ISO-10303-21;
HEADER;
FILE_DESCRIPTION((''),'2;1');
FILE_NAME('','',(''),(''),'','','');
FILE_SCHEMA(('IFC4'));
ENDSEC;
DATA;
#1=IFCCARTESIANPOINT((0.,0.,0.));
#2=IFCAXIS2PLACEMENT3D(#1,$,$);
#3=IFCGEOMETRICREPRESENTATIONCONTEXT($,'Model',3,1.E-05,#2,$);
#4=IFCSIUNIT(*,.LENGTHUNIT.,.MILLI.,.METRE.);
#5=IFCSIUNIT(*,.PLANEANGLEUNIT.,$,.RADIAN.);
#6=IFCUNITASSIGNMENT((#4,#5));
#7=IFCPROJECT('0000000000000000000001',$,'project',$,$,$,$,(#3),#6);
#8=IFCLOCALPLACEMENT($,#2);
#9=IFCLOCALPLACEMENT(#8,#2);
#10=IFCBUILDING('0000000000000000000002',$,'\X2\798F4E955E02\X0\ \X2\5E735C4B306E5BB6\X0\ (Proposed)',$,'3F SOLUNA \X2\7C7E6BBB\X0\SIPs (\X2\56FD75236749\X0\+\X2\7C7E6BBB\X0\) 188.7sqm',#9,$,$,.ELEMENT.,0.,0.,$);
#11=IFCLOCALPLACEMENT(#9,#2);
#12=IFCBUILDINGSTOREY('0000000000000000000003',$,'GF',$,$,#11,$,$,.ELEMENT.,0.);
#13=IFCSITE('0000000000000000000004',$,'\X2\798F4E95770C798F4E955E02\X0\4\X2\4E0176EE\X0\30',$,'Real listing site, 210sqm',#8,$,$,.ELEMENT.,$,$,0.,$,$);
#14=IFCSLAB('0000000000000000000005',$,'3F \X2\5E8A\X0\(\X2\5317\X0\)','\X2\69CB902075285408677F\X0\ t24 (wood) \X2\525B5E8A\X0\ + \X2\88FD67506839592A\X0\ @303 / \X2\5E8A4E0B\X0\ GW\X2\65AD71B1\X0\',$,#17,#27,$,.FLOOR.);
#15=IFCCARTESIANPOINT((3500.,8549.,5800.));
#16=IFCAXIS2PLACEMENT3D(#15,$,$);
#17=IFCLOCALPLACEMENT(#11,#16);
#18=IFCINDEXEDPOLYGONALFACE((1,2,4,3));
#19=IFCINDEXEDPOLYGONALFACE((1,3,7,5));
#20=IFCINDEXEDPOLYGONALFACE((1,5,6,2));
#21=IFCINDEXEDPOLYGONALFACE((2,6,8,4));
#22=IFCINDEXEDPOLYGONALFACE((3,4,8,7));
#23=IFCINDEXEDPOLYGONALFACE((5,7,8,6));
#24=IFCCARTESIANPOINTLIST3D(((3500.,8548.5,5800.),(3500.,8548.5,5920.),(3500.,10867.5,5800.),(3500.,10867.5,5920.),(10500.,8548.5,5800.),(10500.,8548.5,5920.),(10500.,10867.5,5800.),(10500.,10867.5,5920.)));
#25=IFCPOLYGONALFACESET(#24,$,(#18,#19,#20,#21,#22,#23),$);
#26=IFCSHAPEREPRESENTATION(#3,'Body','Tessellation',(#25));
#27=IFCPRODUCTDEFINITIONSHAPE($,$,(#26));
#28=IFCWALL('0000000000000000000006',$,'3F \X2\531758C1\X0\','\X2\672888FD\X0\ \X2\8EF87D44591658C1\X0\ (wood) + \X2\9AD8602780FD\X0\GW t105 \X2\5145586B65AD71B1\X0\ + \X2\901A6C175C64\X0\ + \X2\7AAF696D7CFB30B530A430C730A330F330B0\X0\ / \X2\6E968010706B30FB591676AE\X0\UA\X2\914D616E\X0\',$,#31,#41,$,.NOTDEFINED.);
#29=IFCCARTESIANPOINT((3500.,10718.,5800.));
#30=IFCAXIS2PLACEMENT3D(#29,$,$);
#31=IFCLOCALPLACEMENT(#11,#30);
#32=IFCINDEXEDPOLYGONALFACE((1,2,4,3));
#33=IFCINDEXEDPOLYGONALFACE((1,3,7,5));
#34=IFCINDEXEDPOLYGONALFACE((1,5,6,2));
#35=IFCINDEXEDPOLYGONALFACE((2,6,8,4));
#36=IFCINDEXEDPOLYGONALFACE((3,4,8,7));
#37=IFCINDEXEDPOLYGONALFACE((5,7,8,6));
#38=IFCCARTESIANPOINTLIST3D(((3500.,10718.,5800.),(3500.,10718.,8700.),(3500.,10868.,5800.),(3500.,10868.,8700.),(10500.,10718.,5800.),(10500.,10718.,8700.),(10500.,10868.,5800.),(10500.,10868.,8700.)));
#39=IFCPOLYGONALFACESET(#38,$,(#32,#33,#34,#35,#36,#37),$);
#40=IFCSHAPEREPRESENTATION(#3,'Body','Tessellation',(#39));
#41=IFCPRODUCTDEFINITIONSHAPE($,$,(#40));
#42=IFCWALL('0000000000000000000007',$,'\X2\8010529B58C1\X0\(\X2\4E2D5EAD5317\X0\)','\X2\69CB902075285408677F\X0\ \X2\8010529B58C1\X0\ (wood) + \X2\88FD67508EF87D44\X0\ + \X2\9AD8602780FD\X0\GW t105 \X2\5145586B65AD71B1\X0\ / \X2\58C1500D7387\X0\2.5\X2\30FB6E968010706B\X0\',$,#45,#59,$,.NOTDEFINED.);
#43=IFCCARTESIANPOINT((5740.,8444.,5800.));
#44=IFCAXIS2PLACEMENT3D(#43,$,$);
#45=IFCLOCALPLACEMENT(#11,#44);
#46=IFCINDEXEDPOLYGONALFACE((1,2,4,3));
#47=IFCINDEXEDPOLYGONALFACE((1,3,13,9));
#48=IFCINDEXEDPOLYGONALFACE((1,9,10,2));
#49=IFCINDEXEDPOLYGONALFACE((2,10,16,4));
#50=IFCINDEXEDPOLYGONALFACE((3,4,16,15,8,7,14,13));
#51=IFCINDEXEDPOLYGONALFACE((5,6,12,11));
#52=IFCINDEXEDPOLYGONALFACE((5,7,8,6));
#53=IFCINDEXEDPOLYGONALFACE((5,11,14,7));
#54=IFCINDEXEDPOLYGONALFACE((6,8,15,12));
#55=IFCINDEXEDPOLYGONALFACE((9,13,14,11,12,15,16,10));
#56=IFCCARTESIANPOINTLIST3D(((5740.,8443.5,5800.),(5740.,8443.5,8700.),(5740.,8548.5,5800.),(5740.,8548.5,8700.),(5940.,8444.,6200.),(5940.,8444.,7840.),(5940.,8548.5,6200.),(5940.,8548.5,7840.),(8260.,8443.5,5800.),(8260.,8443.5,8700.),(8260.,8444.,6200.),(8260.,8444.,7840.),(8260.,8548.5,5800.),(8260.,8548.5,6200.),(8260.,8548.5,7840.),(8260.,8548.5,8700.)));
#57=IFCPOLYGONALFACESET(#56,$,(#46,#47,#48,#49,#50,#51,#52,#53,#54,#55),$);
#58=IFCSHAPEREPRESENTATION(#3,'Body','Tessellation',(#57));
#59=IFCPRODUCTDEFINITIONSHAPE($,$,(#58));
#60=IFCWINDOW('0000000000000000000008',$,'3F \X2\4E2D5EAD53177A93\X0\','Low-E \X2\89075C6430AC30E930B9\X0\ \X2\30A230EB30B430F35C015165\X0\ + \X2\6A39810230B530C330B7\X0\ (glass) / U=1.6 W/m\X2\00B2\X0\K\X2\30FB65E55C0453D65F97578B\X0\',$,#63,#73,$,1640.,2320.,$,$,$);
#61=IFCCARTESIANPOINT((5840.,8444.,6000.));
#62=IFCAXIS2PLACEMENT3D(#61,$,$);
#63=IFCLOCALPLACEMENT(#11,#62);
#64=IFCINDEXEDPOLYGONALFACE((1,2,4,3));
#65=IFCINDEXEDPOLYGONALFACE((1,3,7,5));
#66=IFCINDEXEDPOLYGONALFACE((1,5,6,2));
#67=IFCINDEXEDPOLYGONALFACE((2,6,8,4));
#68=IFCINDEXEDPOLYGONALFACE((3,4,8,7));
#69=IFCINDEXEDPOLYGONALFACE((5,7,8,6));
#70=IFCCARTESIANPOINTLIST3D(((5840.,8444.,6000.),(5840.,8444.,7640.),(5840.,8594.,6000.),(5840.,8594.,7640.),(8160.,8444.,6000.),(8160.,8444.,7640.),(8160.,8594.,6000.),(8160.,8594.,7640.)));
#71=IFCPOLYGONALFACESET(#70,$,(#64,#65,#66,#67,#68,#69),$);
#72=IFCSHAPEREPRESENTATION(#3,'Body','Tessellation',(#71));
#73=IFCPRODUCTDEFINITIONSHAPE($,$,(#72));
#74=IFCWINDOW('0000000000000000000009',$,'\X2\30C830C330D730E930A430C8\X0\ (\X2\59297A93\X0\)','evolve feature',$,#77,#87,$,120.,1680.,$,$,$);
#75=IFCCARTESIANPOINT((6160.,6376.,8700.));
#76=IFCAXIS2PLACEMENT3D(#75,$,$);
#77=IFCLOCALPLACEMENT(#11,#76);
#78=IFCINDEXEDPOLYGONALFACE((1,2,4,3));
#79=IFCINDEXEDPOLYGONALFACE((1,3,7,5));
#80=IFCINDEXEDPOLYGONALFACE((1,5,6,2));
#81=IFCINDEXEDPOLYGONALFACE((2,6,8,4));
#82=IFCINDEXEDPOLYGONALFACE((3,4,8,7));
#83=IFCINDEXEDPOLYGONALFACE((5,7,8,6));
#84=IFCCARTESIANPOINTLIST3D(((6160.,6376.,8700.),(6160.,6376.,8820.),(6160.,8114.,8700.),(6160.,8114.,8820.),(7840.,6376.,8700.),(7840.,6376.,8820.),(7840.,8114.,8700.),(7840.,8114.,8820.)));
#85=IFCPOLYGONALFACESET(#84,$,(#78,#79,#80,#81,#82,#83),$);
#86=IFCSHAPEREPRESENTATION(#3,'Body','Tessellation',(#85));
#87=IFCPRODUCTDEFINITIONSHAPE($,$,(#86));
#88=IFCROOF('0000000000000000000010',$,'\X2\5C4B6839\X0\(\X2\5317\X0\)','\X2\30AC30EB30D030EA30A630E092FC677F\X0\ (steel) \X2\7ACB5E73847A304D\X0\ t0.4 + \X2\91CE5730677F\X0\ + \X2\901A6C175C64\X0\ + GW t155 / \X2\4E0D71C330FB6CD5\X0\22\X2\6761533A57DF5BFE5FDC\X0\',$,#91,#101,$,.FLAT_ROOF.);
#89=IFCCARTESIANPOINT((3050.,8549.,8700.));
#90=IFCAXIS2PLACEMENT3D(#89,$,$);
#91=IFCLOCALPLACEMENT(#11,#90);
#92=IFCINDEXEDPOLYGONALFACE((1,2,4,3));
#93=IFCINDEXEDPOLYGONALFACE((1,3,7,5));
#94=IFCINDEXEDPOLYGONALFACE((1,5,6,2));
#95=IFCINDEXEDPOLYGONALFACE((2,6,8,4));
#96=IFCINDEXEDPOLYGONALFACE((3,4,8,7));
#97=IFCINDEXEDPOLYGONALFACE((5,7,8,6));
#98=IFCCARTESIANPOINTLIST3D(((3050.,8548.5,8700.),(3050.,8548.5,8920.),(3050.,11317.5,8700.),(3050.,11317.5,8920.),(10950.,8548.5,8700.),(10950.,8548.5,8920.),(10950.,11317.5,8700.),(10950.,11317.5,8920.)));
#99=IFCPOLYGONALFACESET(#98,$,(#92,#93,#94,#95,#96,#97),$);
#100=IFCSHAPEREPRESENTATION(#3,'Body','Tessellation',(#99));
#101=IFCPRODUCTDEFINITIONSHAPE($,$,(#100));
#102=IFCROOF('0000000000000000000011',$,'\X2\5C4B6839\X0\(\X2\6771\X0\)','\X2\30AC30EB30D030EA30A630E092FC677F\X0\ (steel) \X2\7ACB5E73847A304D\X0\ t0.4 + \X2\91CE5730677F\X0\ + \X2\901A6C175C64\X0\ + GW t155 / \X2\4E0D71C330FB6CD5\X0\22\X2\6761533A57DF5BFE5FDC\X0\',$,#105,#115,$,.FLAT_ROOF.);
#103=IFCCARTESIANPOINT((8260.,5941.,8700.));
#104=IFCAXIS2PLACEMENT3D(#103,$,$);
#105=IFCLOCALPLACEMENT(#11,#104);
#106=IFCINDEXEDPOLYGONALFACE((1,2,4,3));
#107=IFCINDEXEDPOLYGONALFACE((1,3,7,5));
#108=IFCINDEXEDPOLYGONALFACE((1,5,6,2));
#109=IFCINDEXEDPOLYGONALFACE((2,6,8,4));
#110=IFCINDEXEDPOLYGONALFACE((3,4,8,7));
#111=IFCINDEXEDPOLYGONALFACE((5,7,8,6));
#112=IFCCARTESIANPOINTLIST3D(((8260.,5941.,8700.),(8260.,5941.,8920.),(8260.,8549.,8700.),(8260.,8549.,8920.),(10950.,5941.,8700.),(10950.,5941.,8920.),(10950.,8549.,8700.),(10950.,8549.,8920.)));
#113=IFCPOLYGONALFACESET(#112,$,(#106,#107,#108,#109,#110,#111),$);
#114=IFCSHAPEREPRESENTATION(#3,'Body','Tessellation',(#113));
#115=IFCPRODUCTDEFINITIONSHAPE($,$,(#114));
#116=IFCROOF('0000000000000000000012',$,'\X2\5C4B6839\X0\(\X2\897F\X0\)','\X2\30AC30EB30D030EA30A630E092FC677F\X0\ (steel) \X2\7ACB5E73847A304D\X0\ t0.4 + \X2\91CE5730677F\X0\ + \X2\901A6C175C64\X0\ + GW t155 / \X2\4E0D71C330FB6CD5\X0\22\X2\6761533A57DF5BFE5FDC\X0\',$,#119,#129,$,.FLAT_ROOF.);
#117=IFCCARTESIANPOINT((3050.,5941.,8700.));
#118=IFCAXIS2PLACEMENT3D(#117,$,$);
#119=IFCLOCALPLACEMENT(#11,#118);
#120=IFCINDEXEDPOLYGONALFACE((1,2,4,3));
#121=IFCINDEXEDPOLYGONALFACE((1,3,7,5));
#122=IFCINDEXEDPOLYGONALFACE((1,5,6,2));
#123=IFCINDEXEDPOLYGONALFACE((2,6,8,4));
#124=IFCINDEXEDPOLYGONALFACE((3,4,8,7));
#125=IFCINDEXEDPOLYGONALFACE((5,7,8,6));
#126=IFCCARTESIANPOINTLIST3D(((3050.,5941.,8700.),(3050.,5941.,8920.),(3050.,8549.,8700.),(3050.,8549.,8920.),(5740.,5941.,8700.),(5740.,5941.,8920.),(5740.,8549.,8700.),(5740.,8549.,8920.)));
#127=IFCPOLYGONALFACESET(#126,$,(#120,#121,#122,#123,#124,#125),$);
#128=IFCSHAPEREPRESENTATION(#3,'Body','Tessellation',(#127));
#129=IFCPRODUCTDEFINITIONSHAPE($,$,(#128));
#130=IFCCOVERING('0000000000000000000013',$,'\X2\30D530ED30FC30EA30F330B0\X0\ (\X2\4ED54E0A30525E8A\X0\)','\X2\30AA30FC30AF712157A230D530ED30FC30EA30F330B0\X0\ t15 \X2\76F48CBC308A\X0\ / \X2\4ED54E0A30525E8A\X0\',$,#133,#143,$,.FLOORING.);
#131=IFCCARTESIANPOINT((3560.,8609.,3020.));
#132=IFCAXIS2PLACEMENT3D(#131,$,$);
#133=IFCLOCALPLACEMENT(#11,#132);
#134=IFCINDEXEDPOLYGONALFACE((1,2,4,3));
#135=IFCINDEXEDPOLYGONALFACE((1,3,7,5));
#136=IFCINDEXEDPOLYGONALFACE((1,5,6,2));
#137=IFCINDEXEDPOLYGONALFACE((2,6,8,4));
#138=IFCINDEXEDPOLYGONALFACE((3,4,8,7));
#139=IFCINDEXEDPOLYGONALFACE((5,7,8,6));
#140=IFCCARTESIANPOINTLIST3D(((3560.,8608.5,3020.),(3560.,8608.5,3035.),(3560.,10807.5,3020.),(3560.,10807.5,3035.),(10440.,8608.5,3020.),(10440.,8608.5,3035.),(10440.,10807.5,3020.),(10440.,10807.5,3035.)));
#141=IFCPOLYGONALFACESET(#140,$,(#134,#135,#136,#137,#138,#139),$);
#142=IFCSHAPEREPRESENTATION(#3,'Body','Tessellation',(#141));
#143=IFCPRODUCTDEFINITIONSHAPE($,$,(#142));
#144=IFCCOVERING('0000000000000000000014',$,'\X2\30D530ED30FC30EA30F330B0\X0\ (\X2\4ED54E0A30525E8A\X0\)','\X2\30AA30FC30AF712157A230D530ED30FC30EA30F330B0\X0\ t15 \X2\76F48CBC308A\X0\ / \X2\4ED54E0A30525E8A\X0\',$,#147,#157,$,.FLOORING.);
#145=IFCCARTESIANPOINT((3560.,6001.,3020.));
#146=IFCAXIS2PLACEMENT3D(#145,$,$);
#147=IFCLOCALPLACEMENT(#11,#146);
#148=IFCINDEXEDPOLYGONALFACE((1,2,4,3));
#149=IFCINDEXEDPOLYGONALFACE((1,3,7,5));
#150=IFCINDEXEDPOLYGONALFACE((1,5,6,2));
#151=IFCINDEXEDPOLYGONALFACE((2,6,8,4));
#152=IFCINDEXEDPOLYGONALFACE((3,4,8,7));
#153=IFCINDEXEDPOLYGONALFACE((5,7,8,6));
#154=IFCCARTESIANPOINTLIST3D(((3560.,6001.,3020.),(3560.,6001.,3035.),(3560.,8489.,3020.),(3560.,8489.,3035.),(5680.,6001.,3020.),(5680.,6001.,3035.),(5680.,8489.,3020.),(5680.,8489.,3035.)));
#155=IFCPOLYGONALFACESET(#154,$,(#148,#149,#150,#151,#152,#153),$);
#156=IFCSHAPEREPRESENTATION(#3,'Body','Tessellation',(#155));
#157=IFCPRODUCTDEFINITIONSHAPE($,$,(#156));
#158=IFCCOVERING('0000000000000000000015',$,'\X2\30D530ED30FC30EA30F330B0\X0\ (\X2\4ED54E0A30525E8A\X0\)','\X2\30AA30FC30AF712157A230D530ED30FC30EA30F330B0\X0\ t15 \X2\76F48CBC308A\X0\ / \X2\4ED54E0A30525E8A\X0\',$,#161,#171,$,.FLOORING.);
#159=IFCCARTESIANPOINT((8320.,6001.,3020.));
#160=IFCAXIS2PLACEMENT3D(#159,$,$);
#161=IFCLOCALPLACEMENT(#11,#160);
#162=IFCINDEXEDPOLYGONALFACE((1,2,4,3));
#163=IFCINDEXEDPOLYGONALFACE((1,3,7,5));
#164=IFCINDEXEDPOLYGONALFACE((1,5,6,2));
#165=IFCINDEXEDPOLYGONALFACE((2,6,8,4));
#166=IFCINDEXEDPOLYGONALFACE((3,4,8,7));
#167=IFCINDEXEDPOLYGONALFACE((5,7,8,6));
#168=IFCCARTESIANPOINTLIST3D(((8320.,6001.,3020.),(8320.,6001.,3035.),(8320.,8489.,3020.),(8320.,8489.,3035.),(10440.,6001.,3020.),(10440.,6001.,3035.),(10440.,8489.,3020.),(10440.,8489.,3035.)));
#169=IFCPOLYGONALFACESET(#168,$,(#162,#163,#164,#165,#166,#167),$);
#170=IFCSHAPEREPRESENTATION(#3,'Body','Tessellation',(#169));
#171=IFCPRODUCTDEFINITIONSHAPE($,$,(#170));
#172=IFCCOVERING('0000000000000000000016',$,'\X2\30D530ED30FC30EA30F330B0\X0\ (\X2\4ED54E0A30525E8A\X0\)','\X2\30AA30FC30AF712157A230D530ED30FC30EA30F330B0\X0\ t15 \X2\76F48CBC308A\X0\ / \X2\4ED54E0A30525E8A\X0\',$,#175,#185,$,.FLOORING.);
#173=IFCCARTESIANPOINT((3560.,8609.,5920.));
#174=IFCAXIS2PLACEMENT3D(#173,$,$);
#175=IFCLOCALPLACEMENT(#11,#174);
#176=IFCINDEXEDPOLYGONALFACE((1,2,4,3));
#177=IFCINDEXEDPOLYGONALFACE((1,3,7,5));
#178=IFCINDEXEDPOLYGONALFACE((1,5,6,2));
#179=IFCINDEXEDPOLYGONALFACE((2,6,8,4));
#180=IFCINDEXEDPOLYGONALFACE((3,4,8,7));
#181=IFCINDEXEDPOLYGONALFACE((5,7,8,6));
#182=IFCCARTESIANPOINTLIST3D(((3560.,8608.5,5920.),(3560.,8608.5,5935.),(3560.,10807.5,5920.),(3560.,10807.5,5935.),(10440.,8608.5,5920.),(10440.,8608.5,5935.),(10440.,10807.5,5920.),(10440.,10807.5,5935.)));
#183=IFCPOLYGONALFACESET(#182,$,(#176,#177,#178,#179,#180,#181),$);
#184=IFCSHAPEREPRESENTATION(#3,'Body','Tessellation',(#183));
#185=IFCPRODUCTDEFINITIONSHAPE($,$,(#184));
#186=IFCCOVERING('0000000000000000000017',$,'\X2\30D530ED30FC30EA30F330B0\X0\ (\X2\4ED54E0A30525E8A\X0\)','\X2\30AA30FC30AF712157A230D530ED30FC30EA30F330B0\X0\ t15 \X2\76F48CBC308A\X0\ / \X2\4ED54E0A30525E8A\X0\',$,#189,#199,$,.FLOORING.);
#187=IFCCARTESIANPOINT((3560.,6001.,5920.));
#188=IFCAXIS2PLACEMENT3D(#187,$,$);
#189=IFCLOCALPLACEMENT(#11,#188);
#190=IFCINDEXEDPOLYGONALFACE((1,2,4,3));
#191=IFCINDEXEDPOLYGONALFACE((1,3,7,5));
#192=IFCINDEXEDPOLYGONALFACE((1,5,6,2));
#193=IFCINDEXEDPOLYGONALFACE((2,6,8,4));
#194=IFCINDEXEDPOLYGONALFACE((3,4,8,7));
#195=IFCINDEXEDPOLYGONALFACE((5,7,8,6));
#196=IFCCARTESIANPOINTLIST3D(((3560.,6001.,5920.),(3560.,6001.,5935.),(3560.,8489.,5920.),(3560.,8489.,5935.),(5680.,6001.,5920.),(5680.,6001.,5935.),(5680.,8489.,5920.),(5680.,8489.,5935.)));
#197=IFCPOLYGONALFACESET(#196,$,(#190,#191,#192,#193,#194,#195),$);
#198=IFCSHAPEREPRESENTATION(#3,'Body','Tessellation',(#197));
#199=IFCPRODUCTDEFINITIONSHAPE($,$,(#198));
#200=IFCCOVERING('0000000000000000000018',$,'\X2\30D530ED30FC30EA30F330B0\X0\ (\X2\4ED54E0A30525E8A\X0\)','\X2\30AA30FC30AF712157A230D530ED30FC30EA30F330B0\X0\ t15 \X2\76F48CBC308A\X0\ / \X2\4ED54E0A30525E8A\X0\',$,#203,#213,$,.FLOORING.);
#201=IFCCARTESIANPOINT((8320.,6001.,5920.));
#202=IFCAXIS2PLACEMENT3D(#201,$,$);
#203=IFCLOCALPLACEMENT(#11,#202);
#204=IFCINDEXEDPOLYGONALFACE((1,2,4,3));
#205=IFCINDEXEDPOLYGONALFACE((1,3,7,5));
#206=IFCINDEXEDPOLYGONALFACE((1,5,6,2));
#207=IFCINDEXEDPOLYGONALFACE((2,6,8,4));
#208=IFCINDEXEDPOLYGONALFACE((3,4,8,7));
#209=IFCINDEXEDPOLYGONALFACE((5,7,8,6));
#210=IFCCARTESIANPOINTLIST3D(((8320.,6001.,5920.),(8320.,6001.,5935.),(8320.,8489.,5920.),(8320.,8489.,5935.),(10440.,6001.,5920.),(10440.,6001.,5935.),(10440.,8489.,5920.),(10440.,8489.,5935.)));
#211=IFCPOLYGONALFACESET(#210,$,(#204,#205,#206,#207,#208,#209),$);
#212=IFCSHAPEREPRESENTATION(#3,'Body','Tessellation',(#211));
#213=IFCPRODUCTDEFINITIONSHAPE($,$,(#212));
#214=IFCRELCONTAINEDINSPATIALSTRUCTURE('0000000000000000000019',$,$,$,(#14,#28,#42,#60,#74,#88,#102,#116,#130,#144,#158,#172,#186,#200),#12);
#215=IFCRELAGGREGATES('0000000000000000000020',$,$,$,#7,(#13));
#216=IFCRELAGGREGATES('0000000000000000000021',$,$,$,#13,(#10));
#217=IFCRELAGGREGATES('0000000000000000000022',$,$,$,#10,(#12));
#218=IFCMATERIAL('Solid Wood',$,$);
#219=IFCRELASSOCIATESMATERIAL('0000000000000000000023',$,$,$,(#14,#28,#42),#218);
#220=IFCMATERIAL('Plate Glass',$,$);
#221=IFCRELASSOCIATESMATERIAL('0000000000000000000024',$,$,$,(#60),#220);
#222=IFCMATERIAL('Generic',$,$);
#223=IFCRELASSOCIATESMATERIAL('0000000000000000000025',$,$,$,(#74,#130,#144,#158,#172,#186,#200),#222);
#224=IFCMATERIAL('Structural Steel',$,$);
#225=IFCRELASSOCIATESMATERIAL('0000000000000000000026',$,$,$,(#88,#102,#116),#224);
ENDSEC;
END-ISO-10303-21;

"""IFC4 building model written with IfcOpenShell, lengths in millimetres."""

from ifc_helpers import new_model, si_unit, frame, frame_2d, origin, place, context, project, spatial, rectangle, extrude, material, element, fill, save


model = new_model("IFC4")

# Units and contexts
model_context = context("Model", 3, precision=1e-05, world=origin())
ifc_project = project(units=[si_unit("LENGTHUNIT", "METRE", prefix="MILLI"), si_unit("PLANEANGLEUNIT", "RADIAN")], contexts=[model_context])

# Site, building, storey
site_placement = place(None, origin())
site = spatial("IfcSite", under=ifc_project, at=site_placement, Name="福井県福井市4丁目30", ObjectType="Real listing site, 210sqm", CompositionType="ELEMENT", RefElevation=0.0)
building_placement = place(site_placement, origin())
building = spatial("IfcBuilding", under=site, at=building_placement, Name="福井市 平屋の家 (Proposed)", ObjectType="3F SOLUNA 籾殻SIPs (国産杉+籾殻) 188.7sqm", CompositionType="ELEMENT", ElevationOfRefHeight=0.0, ElevationOfTerrain=0.0)
storey_placement = place(building_placement, origin())
storey = spatial("IfcBuildingStorey", under=building, at=storey_placement, Name="GF", CompositionType="ELEMENT", Elevation=0.0)

# Slab
ifc_material_1 = material(Name="Solid Wood")
slab_placement = place(storey_placement, frame((3500.0, 8549.0, 5800.0)))
element("IfcSlab", 1, at=slab_placement, inside=storey, material=ifc_material_1, Name="3F 床(北)", Description="構造用合板 t24 (wood) 剛床 + 製材根太 @303 / 床下 GW断熱", PredefinedType="FLOOR", context=model_context, shape_type="SweptSolid", body=[
    extrude(rectangle(XDim=7000.0, YDim=2319.0, at=frame_2d((3500.0, 1159.0))), frame((3500.0, 8549.0, 5800.0)), (0.0, 0.0, 1.0), 120.0),
])

# Wall
wall_1_placement = place(storey_placement, frame((3500.0, 10718.0, 5800.0)))
element("IfcWall", 2, at=wall_1_placement, inside=storey, material=ifc_material_1, Name="3F 北壁", Description="木製 軸組外壁 (wood) + 高性能GW t105 充填断熱 + 通気層 + 窯業系サイディング / 準耐火・外皮UA配慮", PredefinedType="NOTDEFINED", context=model_context, shape_type="SweptSolid", body=[
    extrude(rectangle(XDim=7000.0, YDim=150.0, at=frame_2d((3500.0, 75.0))), frame((3500.0, 10718.0, 5800.0)), (0.0, 0.0, 1.0), 2900.0),
])

# Wall, opening, window
wall_2_placement = place(storey_placement, frame((5740.0, 8444.0, 5800.0)))
wall_2 = element("IfcWall", 3, at=wall_2_placement, inside=storey, material=ifc_material_1, Name="耐力壁(中庭北)", Description="構造用合板 耐力壁 (wood) + 製材軸組 + 高性能GW t105 充填断熱 / 壁倍率2.5・準耐火", PredefinedType="NOTDEFINED", context=model_context, shape_type="SweptSolid", body=[
    extrude(rectangle(XDim=2520.0, YDim=105.0, at=frame_2d((1260.0, 52.0))), frame((5740.0, 8444.0, 5800.0)), (0.0, 0.0, 1.0), 2900.0),
])
opening_placement = place(storey_placement, frame((5840.0, 8444.0, 6000.0)))
opening = element("IfcOpeningElement", 4, at=opening_placement, cuts=wall_2, PredefinedType="NOTDEFINED", context=model_context, shape_type="SweptSolid", body=[
    extrude(rectangle(XDim=2320.0, YDim=150.0, at=frame_2d((1160.0, 75.0))), frame((5840.0, 8444.0, 6000.0)), (0.0, 0.0, 1.0), 1640.0),
])
ifc_material_2 = material(Name="Plate Glass")
window_1_placement = place(storey_placement, frame((5840.0, 8444.0, 6000.0)))
window_1 = element("IfcWindow", 5, at=window_1_placement, inside=storey, material=ifc_material_2, Name="3F 中庭北窓", Description="Low-E 複層ガラス アルゴン封入 + 樹脂サッシ (glass) / U=1.6 W/m²K・日射取得型", OverallHeight=1640.0, OverallWidth=2320.0, context=model_context, shape_type="SweptSolid", body=[
    extrude(rectangle(XDim=2320.0, YDim=150.0, at=frame_2d((1160.0, 75.0))), frame((5840.0, 8444.0, 6000.0)), (0.0, 0.0, 1.0), 1640.0),
])
fill(opening, window_1)

# Window
ifc_material_3 = material(Name="Generic")
window_2_placement = place(storey_placement, frame((6160.0, 6376.0, 8700.0)))
element("IfcWindow", 6, at=window_2_placement, inside=storey, material=ifc_material_3, Name="トップライト (天窓)", Description="evolve feature", OverallHeight=120.0, OverallWidth=1680.0, context=model_context, shape_type="SweptSolid", body=[
    extrude(rectangle(XDim=1680.0, YDim=1738.0, at=frame_2d((840.0, 869.0))), frame((6160.0, 6376.0, 8700.0)), (0.0, 0.0, 1.0), 120.0),
])

# Roofs
ifc_material_4 = material(Name="Structural Steel")
roof_1_placement = place(storey_placement, frame((3050.0, 8549.0, 8700.0)))
element("IfcRoof", 7, at=roof_1_placement, inside=storey, material=ifc_material_4, Name="屋根(北)", Description="ガルバリウム鋼板 (steel) 立平葺き t0.4 + 野地板 + 通気層 + GW t155 / 不燃・法22条区域対応", PredefinedType="FLAT_ROOF", context=model_context, shape_type="SweptSolid", body=[
    extrude(rectangle(XDim=7900.0, YDim=2769.0, at=frame_2d((3950.0, 1384.0))), frame((3050.0, 8549.0, 8700.0)), (0.0, 0.0, 1.0), 220.0),
])
roof_2_placement = place(storey_placement, frame((8260.0, 5941.0, 8700.0)))
element("IfcRoof", 8, at=roof_2_placement, inside=storey, material=ifc_material_4, Name="屋根(東)", Description="ガルバリウム鋼板 (steel) 立平葺き t0.4 + 野地板 + 通気層 + GW t155 / 不燃・法22条区域対応", PredefinedType="FLAT_ROOF", context=model_context, shape_type="SweptSolid", body=[
    extrude(rectangle(XDim=2690.0, YDim=2608.0, at=frame_2d((1345.0, 1304.0))), frame((8260.0, 5941.0, 8700.0)), (0.0, 0.0, 1.0), 220.0),
])
roof_3_placement = place(storey_placement, frame((3050.0, 5941.0, 8700.0)))
element("IfcRoof", 9, at=roof_3_placement, inside=storey, material=ifc_material_4, Name="屋根(西)", Description="ガルバリウム鋼板 (steel) 立平葺き t0.4 + 野地板 + 通気層 + GW t155 / 不燃・法22条区域対応", PredefinedType="FLAT_ROOF", context=model_context, shape_type="SweptSolid", body=[
    extrude(rectangle(XDim=2690.0, YDim=2608.0, at=frame_2d((1345.0, 1304.0))), frame((3050.0, 5941.0, 8700.0)), (0.0, 0.0, 1.0), 220.0),
])

# Coverings
covering_1_placement = place(storey_placement, frame((3560.0, 8609.0, 3020.0)))
element("IfcCovering", 10, at=covering_1_placement, inside=storey, material=ifc_material_3, Name="フローリング (仕上げ床)", Description="オーク無垢フローリング t15 直貼り / 仕上げ床", PredefinedType="FLOORING", context=model_context, shape_type="SweptSolid", body=[
    extrude(rectangle(XDim=6880.0, YDim=2199.0, at=frame_2d((3440.0, 1099.0))), frame((3560.0, 8609.0, 3020.0)), (0.0, 0.0, 1.0), 15.0),
])
covering_2_placement = place(storey_placement, frame((3560.0, 6001.0, 3020.0)))
element("IfcCovering", 11, at=covering_2_placement, inside=storey, material=ifc_material_3, Name="フローリング (仕上げ床)", Description="オーク無垢フローリング t15 直貼り / 仕上げ床", PredefinedType="FLOORING", context=model_context, shape_type="SweptSolid", body=[
    extrude(rectangle(XDim=2120.0, YDim=2488.0, at=frame_2d((1060.0, 1244.0))), frame((3560.0, 6001.0, 3020.0)), (0.0, 0.0, 1.0), 15.0),
])
covering_3_placement = place(storey_placement, frame((8320.0, 6001.0, 3020.0)))
element("IfcCovering", 12, at=covering_3_placement, inside=storey, material=ifc_material_3, Name="フローリング (仕上げ床)", Description="オーク無垢フローリング t15 直貼り / 仕上げ床", PredefinedType="FLOORING", context=model_context, shape_type="SweptSolid", body=[
    extrude(rectangle(XDim=2120.0, YDim=2488.0, at=frame_2d((1060.0, 1244.0))), frame((8320.0, 6001.0, 3020.0)), (0.0, 0.0, 1.0), 15.0),
])
covering_4_placement = place(storey_placement, frame((3560.0, 8609.0, 5920.0)))
element("IfcCovering", 13, at=covering_4_placement, inside=storey, material=ifc_material_3, Name="フローリング (仕上げ床)", Description="オーク無垢フローリング t15 直貼り / 仕上げ床", PredefinedType="FLOORING", context=model_context, shape_type="SweptSolid", body=[
    extrude(rectangle(XDim=6880.0, YDim=2199.0, at=frame_2d((3440.0, 1099.0))), frame((3560.0, 8609.0, 5920.0)), (0.0, 0.0, 1.0), 15.0),
])
covering_5_placement = place(storey_placement, frame((3560.0, 6001.0, 5920.0)))
element("IfcCovering", 14, at=covering_5_placement, inside=storey, material=ifc_material_3, Name="フローリング (仕上げ床)", Description="オーク無垢フローリング t15 直貼り / 仕上げ床", PredefinedType="FLOORING", context=model_context, shape_type="SweptSolid", body=[
    extrude(rectangle(XDim=2120.0, YDim=2488.0, at=frame_2d((1060.0, 1244.0))), frame((3560.0, 6001.0, 5920.0)), (0.0, 0.0, 1.0), 15.0),
])
covering_6_placement = place(storey_placement, frame((8320.0, 6001.0, 5920.0)))
element("IfcCovering", 15, at=covering_6_placement, inside=storey, material=ifc_material_3, Name="フローリング (仕上げ床)", Description="オーク無垢フローリング t15 直貼り / 仕上げ床", PredefinedType="FLOORING", context=model_context, shape_type="SweptSolid", body=[
    extrude(rectangle(XDim=2120.0, YDim=2488.0, at=frame_2d((1060.0, 1244.0))), frame((8320.0, 6001.0, 5920.0)), (0.0, 0.0, 1.0), 15.0),
])

save(model, "model.ifc")
